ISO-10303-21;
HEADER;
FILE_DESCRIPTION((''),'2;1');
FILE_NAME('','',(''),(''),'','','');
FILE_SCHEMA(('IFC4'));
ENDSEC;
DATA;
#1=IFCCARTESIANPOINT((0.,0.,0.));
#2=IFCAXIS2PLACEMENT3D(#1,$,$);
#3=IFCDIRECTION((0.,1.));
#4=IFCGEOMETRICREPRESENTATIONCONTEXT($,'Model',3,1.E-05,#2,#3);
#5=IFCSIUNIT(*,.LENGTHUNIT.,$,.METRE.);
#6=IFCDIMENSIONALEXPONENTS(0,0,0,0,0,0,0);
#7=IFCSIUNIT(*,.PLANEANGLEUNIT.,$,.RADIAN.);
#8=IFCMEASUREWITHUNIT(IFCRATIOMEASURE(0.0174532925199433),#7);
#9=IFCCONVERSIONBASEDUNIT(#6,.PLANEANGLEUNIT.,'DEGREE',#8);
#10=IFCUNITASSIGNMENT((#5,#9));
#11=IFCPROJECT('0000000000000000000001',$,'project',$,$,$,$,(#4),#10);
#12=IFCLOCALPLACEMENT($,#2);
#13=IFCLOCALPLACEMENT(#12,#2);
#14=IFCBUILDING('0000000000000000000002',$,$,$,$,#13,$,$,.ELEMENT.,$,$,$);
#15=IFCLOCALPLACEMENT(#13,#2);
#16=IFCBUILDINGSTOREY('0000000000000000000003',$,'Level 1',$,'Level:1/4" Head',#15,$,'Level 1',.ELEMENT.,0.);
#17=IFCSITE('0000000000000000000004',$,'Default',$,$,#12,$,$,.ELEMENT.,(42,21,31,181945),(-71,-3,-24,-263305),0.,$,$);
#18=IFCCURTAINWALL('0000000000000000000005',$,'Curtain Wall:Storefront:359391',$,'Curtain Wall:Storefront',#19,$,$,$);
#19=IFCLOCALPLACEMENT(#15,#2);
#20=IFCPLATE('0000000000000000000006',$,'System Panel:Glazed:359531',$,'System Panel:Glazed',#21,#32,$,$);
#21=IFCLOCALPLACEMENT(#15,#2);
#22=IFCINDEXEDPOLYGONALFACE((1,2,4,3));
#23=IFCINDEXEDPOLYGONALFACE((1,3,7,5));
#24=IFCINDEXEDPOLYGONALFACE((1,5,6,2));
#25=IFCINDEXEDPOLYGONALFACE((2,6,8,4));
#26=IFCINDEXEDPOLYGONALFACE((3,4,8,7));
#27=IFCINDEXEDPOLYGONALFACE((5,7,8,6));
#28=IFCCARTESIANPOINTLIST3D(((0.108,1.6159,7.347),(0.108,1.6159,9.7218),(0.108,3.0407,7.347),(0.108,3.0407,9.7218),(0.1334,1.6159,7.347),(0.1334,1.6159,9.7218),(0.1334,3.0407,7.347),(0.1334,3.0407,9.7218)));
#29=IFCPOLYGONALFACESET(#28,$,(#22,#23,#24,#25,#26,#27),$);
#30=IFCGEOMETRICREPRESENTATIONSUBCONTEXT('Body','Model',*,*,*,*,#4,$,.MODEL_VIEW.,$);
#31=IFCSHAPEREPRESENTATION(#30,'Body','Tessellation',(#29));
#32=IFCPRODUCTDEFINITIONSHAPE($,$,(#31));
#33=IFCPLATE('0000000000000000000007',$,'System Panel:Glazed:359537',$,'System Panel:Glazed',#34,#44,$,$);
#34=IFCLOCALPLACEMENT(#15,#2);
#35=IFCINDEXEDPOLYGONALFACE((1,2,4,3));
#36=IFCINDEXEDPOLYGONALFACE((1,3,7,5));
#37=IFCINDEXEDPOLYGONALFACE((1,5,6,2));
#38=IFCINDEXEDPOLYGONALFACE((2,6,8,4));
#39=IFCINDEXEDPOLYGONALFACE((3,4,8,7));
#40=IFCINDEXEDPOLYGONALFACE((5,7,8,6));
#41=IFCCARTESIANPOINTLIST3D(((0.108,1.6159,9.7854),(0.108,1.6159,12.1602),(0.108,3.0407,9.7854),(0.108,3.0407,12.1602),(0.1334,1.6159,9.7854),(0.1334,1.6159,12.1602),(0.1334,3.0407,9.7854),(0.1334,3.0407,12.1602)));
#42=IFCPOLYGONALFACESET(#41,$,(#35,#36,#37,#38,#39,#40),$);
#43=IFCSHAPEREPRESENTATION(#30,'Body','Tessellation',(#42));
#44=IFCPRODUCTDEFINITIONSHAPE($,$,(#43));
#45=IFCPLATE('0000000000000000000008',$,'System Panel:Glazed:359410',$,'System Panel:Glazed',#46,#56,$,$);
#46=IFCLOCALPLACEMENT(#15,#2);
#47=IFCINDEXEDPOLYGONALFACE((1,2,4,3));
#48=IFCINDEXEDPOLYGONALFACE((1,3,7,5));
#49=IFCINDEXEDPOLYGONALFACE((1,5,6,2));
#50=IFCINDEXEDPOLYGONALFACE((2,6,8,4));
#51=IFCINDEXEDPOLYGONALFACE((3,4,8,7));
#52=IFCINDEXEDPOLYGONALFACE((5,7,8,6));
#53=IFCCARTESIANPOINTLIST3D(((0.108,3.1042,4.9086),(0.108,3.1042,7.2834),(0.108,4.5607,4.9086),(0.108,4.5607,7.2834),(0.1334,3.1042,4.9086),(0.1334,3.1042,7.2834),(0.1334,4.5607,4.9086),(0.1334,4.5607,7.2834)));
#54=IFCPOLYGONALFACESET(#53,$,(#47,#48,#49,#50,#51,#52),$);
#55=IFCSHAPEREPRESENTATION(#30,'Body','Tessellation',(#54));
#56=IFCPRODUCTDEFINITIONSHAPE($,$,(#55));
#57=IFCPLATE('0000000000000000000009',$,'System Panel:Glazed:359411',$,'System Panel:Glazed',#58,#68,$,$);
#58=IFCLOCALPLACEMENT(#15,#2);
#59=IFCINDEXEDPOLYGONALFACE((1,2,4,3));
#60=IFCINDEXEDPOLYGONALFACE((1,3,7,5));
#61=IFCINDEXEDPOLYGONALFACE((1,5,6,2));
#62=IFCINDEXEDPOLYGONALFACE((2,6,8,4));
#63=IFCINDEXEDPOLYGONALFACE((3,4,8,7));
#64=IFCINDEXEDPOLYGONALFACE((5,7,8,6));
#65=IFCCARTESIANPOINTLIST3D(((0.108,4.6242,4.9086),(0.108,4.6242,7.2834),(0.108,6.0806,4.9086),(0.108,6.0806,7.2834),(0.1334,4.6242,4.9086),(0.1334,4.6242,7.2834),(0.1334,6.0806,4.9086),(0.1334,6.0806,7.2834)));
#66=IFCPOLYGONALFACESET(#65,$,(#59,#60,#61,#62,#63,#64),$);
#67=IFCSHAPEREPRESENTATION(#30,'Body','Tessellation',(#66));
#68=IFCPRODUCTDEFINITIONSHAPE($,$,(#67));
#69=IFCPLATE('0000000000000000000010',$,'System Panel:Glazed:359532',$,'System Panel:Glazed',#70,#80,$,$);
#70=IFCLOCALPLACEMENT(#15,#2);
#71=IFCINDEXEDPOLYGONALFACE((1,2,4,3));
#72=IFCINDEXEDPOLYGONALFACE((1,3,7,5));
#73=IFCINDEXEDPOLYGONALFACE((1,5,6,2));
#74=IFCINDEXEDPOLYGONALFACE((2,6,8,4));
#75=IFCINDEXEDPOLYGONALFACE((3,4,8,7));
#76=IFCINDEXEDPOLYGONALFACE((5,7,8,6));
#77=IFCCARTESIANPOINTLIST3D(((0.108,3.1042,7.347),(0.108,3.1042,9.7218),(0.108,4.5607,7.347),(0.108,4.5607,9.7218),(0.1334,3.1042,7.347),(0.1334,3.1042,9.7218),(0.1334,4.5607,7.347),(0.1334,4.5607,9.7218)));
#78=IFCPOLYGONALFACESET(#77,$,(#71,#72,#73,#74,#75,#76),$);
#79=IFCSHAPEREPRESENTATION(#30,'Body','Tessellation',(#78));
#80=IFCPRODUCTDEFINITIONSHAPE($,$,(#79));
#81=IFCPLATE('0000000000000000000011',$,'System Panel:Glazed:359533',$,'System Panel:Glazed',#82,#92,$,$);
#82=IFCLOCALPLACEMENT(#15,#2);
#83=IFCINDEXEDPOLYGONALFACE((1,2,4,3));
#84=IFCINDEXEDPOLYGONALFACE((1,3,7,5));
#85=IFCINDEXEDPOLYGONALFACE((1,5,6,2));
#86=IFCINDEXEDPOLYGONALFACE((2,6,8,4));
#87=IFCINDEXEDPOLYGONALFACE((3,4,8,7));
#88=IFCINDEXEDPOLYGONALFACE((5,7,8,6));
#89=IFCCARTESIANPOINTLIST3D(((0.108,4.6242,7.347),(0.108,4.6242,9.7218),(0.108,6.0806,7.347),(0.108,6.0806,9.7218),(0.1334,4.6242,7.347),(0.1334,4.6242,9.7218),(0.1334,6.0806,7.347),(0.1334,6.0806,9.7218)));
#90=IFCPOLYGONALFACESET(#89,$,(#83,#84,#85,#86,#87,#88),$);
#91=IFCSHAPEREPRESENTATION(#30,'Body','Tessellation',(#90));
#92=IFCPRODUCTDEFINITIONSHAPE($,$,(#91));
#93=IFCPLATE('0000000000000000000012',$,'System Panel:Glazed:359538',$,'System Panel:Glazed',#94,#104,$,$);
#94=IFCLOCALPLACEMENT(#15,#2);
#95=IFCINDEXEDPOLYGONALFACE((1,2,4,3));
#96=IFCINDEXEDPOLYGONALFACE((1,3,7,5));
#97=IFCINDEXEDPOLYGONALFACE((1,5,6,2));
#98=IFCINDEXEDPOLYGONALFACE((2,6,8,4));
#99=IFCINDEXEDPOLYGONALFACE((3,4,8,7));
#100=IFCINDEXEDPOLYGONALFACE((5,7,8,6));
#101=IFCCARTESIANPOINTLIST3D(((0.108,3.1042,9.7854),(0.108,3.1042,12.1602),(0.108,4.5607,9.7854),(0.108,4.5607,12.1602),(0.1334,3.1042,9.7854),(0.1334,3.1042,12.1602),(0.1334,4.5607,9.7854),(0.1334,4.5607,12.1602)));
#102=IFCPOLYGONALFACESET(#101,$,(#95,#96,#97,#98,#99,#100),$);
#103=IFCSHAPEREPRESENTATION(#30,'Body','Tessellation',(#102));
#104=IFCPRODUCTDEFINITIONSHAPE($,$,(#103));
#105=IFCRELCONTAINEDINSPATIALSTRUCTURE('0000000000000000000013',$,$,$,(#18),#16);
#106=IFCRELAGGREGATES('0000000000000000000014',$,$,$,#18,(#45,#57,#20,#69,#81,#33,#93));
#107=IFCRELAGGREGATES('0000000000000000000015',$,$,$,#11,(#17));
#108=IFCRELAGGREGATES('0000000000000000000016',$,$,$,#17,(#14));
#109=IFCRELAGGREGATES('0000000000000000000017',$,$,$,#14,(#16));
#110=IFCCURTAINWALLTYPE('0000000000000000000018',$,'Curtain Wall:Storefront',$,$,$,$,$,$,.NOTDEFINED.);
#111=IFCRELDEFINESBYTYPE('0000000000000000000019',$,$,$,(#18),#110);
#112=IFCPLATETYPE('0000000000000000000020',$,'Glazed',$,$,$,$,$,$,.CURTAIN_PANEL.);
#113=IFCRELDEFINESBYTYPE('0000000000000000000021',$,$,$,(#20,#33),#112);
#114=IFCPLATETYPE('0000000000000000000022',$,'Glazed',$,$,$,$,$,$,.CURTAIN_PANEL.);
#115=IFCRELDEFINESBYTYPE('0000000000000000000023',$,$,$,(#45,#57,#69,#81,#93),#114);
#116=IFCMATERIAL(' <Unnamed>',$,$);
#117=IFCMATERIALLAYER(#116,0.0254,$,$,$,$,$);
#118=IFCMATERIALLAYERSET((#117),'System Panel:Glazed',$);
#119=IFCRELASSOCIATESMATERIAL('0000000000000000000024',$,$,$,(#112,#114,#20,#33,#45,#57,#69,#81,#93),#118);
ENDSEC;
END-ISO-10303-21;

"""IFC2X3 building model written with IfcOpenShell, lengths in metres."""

from ifc_helpers import new_model, entity, si_unit, converted_unit, direction, frame, frame_2d, origin, place, context, subcontext, project, spatial, rectangle, extrude, source, transform, mapped, material, layer, layer_set, layer_usage, type_object, type_shapes, element, aggregate, save


model = new_model("IFC2X3")

# Units and contexts
model_context = context("Model", 3, precision=1e-05, world=origin(), true_north=direction((0.0, 1.0)))
body_context = subcontext(model_context, "Body", "Model", "MODEL_VIEW")
ifc_project = project(units=[si_unit("LENGTHUNIT", "METRE"), converted_unit("PLANEANGLEUNIT", "DEGREE", entity("IfcRatioMeasure", 0.0174532925199433), si_unit("PLANEANGLEUNIT", "RADIAN"), dimensions=[0, 0, 0, 0, 0, 0, 0])], contexts=[model_context])

# Site, building, storey
site_placement = place(None, origin())
site = spatial("IfcSite", under=ifc_project, at=site_placement, Name="Default", CompositionType="ELEMENT", RefLatitude=(42, 21, 31, 181945), RefLongitude=(-71, -3, -24, -263305), RefElevation=0.0)
building_placement = place(site_placement, origin())
building = spatial("IfcBuilding", under=site, at=building_placement, CompositionType="ELEMENT")
storey_placement = place(building_placement, origin())
storey = spatial("IfcBuildingStorey", under=building, at=storey_placement, Name="Level 1", ObjectType="Level:1/4\" Head", LongName="Level 1", CompositionType="ELEMENT", Elevation=0.0)

# Curtain wall, plates
curtain_wall_type = type_object("IfcCurtainWallType", Name="Curtain Wall:Storefront", PredefinedType="NOTDEFINED")
curtain_wall_placement = place(storey_placement, origin())
curtain_wall = element("IfcCurtainWall", 1, at=curtain_wall_placement, inside=storey, type_object=curtain_wall_type, Name="Curtain Wall:Storefront:359391", ObjectType="Curtain Wall:Storefront")
ifc_material_1 = material(Name=" <Unnamed>")
ifc_layer = layer(ifc_material_1, 0.0254)
ifc_layer_set = layer_set([ifc_layer], Name="System Panel:Glazed")
plate_type_1 = type_object("IfcPlateType", Name="Glazed", PredefinedType="CURTAIN_PANEL", material=ifc_layer_set)
shared_shape_1 = source(origin(), body_context, "Body", "SweptSolid", [
    extrude(rectangle(XDim=0.0254, YDim=1.4248, at=frame_2d((0.0, 0.0), x_axis=(1.0, 0.0))), frame((0.7124, 0.0127, 0.0), z_axis=(0.0, 0.0, 1.0), x_axis=(0.0, 1.0, 0.0)), (0.0, 0.0, 1.0), 2.3749),
])
type_shapes(plate_type_1, [shared_shape_1])
ifc_layer_usage_1 = layer_usage(ifc_layer_set, "AXIS3", "POSITIVE", 0.1042)
plate_1_placement = place(curtain_wall_placement, frame((0.1334, 1.6159, 7.3469), z_axis=(0.0, 0.0, 1.0), x_axis=(0.0, 1.0, 0.0)))
plate_1 = element("IfcPlate", 2, at=plate_1_placement, type_object=plate_type_1, material=ifc_layer_usage_1, Name="System Panel:Glazed:359531", ObjectType="System Panel:Glazed", context=body_context, shape_type="MappedRepresentation", body=[
    mapped(shared_shape_1, transform((0.0, 0.0, 0.0), scale=1.0)),
])
ifc_layer_usage_2 = layer_usage(ifc_layer_set, "AXIS3", "POSITIVE", 0.1042)
plate_2_placement = place(curtain_wall_placement, frame((0.1334, 1.6159, 9.7853), z_axis=(0.0, 0.0, 1.0), x_axis=(0.0, 1.0, 0.0)))
plate_2 = element("IfcPlate", 3, at=plate_2_placement, type_object=plate_type_1, material=ifc_layer_usage_2, Name="System Panel:Glazed:359537", ObjectType="System Panel:Glazed", context=body_context, shape_type="MappedRepresentation", body=[
    mapped(shared_shape_1, transform((0.0, 0.0, 0.0), scale=1.0)),
])
ifc_layer_usage_3 = layer_usage(ifc_layer_set, "AXIS3", "POSITIVE", 0.1042)
plate_type_2 = type_object("IfcPlateType", Name="Glazed", PredefinedType="CURTAIN_PANEL", material=ifc_layer_set)
shared_shape_2 = source(origin(), body_context, "Body", "SweptSolid", [
    extrude(rectangle(XDim=0.0254, YDim=1.4565, at=frame_2d((0.0, 0.0), x_axis=(1.0, 0.0))), frame((0.7282, 0.0127, 0.0), z_axis=(0.0, 0.0, 1.0), x_axis=(0.0, 1.0, 0.0)), (0.0, 0.0, 1.0), 2.3749),
])
type_shapes(plate_type_2, [shared_shape_2])
plate_3_placement = place(curtain_wall_placement, frame((0.1334, 3.1042, 4.9085), z_axis=(0.0, 0.0, 1.0), x_axis=(0.0, 1.0, 0.0)))
plate_3 = element("IfcPlate", 4, at=plate_3_placement, type_object=plate_type_2, material=ifc_layer_usage_3, Name="System Panel:Glazed:359410", ObjectType="System Panel:Glazed", context=body_context, shape_type="MappedRepresentation", body=[
    mapped(shared_shape_2, transform((0.0, 0.0, 0.0), scale=1.0)),
])
ifc_layer_usage_4 = layer_usage(ifc_layer_set, "AXIS3", "POSITIVE", 0.1042)
plate_4_placement = place(curtain_wall_placement, frame((0.1334, 4.6242, 4.9085), z_axis=(0.0, 0.0, 1.0), x_axis=(0.0, 1.0, 0.0)))
plate_4 = element("IfcPlate", 5, at=plate_4_placement, type_object=plate_type_2, material=ifc_layer_usage_4, Name="System Panel:Glazed:359411", ObjectType="System Panel:Glazed", context=body_context, shape_type="MappedRepresentation", body=[
    mapped(shared_shape_2, transform((0.0, 0.0, 0.0), scale=1.0)),
])
ifc_layer_usage_5 = layer_usage(ifc_layer_set, "AXIS3", "POSITIVE", 0.1042)
plate_5_placement = place(curtain_wall_placement, frame((0.1334, 3.1042, 7.3469), z_axis=(0.0, 0.0, 1.0), x_axis=(0.0, 1.0, 0.0)))
plate_5 = element("IfcPlate", 6, at=plate_5_placement, type_object=plate_type_2, material=ifc_layer_usage_5, Name="System Panel:Glazed:359532", ObjectType="System Panel:Glazed", context=body_context, shape_type="MappedRepresentation", body=[
    mapped(shared_shape_2, transform((0.0, 0.0, 0.0), scale=1.0)),
])
ifc_layer_usage_6 = layer_usage(ifc_layer_set, "AXIS3", "POSITIVE", 0.1042)
plate_6_placement = place(curtain_wall_placement, frame((0.1334, 4.6242, 7.3469), z_axis=(0.0, 0.0, 1.0), x_axis=(0.0, 1.0, 0.0)))
plate_6 = element("IfcPlate", 7, at=plate_6_placement, type_object=plate_type_2, material=ifc_layer_usage_6, Name="System Panel:Glazed:359533", ObjectType="System Panel:Glazed", context=body_context, shape_type="MappedRepresentation", body=[
    mapped(shared_shape_2, transform((0.0, 0.0, 0.0), scale=1.0)),
])
ifc_layer_usage_7 = layer_usage(ifc_layer_set, "AXIS3", "POSITIVE", 0.1042)
plate_7_placement = place(curtain_wall_placement, frame((0.1334, 3.1042, 9.7853), z_axis=(0.0, 0.0, 1.0), x_axis=(0.0, 1.0, 0.0)))
plate_7 = element("IfcPlate", 8, at=plate_7_placement, type_object=plate_type_2, material=ifc_layer_usage_7, Name="System Panel:Glazed:359538", ObjectType="System Panel:Glazed", context=body_context, shape_type="MappedRepresentation", body=[
    mapped(shared_shape_2, transform((0.0, 0.0, 0.0), scale=1.0)),
])
aggregate(curtain_wall, [plate_3, plate_4, plate_1, plate_5, plate_6, plate_2, plate_7])

save(model, "model.ifc")
